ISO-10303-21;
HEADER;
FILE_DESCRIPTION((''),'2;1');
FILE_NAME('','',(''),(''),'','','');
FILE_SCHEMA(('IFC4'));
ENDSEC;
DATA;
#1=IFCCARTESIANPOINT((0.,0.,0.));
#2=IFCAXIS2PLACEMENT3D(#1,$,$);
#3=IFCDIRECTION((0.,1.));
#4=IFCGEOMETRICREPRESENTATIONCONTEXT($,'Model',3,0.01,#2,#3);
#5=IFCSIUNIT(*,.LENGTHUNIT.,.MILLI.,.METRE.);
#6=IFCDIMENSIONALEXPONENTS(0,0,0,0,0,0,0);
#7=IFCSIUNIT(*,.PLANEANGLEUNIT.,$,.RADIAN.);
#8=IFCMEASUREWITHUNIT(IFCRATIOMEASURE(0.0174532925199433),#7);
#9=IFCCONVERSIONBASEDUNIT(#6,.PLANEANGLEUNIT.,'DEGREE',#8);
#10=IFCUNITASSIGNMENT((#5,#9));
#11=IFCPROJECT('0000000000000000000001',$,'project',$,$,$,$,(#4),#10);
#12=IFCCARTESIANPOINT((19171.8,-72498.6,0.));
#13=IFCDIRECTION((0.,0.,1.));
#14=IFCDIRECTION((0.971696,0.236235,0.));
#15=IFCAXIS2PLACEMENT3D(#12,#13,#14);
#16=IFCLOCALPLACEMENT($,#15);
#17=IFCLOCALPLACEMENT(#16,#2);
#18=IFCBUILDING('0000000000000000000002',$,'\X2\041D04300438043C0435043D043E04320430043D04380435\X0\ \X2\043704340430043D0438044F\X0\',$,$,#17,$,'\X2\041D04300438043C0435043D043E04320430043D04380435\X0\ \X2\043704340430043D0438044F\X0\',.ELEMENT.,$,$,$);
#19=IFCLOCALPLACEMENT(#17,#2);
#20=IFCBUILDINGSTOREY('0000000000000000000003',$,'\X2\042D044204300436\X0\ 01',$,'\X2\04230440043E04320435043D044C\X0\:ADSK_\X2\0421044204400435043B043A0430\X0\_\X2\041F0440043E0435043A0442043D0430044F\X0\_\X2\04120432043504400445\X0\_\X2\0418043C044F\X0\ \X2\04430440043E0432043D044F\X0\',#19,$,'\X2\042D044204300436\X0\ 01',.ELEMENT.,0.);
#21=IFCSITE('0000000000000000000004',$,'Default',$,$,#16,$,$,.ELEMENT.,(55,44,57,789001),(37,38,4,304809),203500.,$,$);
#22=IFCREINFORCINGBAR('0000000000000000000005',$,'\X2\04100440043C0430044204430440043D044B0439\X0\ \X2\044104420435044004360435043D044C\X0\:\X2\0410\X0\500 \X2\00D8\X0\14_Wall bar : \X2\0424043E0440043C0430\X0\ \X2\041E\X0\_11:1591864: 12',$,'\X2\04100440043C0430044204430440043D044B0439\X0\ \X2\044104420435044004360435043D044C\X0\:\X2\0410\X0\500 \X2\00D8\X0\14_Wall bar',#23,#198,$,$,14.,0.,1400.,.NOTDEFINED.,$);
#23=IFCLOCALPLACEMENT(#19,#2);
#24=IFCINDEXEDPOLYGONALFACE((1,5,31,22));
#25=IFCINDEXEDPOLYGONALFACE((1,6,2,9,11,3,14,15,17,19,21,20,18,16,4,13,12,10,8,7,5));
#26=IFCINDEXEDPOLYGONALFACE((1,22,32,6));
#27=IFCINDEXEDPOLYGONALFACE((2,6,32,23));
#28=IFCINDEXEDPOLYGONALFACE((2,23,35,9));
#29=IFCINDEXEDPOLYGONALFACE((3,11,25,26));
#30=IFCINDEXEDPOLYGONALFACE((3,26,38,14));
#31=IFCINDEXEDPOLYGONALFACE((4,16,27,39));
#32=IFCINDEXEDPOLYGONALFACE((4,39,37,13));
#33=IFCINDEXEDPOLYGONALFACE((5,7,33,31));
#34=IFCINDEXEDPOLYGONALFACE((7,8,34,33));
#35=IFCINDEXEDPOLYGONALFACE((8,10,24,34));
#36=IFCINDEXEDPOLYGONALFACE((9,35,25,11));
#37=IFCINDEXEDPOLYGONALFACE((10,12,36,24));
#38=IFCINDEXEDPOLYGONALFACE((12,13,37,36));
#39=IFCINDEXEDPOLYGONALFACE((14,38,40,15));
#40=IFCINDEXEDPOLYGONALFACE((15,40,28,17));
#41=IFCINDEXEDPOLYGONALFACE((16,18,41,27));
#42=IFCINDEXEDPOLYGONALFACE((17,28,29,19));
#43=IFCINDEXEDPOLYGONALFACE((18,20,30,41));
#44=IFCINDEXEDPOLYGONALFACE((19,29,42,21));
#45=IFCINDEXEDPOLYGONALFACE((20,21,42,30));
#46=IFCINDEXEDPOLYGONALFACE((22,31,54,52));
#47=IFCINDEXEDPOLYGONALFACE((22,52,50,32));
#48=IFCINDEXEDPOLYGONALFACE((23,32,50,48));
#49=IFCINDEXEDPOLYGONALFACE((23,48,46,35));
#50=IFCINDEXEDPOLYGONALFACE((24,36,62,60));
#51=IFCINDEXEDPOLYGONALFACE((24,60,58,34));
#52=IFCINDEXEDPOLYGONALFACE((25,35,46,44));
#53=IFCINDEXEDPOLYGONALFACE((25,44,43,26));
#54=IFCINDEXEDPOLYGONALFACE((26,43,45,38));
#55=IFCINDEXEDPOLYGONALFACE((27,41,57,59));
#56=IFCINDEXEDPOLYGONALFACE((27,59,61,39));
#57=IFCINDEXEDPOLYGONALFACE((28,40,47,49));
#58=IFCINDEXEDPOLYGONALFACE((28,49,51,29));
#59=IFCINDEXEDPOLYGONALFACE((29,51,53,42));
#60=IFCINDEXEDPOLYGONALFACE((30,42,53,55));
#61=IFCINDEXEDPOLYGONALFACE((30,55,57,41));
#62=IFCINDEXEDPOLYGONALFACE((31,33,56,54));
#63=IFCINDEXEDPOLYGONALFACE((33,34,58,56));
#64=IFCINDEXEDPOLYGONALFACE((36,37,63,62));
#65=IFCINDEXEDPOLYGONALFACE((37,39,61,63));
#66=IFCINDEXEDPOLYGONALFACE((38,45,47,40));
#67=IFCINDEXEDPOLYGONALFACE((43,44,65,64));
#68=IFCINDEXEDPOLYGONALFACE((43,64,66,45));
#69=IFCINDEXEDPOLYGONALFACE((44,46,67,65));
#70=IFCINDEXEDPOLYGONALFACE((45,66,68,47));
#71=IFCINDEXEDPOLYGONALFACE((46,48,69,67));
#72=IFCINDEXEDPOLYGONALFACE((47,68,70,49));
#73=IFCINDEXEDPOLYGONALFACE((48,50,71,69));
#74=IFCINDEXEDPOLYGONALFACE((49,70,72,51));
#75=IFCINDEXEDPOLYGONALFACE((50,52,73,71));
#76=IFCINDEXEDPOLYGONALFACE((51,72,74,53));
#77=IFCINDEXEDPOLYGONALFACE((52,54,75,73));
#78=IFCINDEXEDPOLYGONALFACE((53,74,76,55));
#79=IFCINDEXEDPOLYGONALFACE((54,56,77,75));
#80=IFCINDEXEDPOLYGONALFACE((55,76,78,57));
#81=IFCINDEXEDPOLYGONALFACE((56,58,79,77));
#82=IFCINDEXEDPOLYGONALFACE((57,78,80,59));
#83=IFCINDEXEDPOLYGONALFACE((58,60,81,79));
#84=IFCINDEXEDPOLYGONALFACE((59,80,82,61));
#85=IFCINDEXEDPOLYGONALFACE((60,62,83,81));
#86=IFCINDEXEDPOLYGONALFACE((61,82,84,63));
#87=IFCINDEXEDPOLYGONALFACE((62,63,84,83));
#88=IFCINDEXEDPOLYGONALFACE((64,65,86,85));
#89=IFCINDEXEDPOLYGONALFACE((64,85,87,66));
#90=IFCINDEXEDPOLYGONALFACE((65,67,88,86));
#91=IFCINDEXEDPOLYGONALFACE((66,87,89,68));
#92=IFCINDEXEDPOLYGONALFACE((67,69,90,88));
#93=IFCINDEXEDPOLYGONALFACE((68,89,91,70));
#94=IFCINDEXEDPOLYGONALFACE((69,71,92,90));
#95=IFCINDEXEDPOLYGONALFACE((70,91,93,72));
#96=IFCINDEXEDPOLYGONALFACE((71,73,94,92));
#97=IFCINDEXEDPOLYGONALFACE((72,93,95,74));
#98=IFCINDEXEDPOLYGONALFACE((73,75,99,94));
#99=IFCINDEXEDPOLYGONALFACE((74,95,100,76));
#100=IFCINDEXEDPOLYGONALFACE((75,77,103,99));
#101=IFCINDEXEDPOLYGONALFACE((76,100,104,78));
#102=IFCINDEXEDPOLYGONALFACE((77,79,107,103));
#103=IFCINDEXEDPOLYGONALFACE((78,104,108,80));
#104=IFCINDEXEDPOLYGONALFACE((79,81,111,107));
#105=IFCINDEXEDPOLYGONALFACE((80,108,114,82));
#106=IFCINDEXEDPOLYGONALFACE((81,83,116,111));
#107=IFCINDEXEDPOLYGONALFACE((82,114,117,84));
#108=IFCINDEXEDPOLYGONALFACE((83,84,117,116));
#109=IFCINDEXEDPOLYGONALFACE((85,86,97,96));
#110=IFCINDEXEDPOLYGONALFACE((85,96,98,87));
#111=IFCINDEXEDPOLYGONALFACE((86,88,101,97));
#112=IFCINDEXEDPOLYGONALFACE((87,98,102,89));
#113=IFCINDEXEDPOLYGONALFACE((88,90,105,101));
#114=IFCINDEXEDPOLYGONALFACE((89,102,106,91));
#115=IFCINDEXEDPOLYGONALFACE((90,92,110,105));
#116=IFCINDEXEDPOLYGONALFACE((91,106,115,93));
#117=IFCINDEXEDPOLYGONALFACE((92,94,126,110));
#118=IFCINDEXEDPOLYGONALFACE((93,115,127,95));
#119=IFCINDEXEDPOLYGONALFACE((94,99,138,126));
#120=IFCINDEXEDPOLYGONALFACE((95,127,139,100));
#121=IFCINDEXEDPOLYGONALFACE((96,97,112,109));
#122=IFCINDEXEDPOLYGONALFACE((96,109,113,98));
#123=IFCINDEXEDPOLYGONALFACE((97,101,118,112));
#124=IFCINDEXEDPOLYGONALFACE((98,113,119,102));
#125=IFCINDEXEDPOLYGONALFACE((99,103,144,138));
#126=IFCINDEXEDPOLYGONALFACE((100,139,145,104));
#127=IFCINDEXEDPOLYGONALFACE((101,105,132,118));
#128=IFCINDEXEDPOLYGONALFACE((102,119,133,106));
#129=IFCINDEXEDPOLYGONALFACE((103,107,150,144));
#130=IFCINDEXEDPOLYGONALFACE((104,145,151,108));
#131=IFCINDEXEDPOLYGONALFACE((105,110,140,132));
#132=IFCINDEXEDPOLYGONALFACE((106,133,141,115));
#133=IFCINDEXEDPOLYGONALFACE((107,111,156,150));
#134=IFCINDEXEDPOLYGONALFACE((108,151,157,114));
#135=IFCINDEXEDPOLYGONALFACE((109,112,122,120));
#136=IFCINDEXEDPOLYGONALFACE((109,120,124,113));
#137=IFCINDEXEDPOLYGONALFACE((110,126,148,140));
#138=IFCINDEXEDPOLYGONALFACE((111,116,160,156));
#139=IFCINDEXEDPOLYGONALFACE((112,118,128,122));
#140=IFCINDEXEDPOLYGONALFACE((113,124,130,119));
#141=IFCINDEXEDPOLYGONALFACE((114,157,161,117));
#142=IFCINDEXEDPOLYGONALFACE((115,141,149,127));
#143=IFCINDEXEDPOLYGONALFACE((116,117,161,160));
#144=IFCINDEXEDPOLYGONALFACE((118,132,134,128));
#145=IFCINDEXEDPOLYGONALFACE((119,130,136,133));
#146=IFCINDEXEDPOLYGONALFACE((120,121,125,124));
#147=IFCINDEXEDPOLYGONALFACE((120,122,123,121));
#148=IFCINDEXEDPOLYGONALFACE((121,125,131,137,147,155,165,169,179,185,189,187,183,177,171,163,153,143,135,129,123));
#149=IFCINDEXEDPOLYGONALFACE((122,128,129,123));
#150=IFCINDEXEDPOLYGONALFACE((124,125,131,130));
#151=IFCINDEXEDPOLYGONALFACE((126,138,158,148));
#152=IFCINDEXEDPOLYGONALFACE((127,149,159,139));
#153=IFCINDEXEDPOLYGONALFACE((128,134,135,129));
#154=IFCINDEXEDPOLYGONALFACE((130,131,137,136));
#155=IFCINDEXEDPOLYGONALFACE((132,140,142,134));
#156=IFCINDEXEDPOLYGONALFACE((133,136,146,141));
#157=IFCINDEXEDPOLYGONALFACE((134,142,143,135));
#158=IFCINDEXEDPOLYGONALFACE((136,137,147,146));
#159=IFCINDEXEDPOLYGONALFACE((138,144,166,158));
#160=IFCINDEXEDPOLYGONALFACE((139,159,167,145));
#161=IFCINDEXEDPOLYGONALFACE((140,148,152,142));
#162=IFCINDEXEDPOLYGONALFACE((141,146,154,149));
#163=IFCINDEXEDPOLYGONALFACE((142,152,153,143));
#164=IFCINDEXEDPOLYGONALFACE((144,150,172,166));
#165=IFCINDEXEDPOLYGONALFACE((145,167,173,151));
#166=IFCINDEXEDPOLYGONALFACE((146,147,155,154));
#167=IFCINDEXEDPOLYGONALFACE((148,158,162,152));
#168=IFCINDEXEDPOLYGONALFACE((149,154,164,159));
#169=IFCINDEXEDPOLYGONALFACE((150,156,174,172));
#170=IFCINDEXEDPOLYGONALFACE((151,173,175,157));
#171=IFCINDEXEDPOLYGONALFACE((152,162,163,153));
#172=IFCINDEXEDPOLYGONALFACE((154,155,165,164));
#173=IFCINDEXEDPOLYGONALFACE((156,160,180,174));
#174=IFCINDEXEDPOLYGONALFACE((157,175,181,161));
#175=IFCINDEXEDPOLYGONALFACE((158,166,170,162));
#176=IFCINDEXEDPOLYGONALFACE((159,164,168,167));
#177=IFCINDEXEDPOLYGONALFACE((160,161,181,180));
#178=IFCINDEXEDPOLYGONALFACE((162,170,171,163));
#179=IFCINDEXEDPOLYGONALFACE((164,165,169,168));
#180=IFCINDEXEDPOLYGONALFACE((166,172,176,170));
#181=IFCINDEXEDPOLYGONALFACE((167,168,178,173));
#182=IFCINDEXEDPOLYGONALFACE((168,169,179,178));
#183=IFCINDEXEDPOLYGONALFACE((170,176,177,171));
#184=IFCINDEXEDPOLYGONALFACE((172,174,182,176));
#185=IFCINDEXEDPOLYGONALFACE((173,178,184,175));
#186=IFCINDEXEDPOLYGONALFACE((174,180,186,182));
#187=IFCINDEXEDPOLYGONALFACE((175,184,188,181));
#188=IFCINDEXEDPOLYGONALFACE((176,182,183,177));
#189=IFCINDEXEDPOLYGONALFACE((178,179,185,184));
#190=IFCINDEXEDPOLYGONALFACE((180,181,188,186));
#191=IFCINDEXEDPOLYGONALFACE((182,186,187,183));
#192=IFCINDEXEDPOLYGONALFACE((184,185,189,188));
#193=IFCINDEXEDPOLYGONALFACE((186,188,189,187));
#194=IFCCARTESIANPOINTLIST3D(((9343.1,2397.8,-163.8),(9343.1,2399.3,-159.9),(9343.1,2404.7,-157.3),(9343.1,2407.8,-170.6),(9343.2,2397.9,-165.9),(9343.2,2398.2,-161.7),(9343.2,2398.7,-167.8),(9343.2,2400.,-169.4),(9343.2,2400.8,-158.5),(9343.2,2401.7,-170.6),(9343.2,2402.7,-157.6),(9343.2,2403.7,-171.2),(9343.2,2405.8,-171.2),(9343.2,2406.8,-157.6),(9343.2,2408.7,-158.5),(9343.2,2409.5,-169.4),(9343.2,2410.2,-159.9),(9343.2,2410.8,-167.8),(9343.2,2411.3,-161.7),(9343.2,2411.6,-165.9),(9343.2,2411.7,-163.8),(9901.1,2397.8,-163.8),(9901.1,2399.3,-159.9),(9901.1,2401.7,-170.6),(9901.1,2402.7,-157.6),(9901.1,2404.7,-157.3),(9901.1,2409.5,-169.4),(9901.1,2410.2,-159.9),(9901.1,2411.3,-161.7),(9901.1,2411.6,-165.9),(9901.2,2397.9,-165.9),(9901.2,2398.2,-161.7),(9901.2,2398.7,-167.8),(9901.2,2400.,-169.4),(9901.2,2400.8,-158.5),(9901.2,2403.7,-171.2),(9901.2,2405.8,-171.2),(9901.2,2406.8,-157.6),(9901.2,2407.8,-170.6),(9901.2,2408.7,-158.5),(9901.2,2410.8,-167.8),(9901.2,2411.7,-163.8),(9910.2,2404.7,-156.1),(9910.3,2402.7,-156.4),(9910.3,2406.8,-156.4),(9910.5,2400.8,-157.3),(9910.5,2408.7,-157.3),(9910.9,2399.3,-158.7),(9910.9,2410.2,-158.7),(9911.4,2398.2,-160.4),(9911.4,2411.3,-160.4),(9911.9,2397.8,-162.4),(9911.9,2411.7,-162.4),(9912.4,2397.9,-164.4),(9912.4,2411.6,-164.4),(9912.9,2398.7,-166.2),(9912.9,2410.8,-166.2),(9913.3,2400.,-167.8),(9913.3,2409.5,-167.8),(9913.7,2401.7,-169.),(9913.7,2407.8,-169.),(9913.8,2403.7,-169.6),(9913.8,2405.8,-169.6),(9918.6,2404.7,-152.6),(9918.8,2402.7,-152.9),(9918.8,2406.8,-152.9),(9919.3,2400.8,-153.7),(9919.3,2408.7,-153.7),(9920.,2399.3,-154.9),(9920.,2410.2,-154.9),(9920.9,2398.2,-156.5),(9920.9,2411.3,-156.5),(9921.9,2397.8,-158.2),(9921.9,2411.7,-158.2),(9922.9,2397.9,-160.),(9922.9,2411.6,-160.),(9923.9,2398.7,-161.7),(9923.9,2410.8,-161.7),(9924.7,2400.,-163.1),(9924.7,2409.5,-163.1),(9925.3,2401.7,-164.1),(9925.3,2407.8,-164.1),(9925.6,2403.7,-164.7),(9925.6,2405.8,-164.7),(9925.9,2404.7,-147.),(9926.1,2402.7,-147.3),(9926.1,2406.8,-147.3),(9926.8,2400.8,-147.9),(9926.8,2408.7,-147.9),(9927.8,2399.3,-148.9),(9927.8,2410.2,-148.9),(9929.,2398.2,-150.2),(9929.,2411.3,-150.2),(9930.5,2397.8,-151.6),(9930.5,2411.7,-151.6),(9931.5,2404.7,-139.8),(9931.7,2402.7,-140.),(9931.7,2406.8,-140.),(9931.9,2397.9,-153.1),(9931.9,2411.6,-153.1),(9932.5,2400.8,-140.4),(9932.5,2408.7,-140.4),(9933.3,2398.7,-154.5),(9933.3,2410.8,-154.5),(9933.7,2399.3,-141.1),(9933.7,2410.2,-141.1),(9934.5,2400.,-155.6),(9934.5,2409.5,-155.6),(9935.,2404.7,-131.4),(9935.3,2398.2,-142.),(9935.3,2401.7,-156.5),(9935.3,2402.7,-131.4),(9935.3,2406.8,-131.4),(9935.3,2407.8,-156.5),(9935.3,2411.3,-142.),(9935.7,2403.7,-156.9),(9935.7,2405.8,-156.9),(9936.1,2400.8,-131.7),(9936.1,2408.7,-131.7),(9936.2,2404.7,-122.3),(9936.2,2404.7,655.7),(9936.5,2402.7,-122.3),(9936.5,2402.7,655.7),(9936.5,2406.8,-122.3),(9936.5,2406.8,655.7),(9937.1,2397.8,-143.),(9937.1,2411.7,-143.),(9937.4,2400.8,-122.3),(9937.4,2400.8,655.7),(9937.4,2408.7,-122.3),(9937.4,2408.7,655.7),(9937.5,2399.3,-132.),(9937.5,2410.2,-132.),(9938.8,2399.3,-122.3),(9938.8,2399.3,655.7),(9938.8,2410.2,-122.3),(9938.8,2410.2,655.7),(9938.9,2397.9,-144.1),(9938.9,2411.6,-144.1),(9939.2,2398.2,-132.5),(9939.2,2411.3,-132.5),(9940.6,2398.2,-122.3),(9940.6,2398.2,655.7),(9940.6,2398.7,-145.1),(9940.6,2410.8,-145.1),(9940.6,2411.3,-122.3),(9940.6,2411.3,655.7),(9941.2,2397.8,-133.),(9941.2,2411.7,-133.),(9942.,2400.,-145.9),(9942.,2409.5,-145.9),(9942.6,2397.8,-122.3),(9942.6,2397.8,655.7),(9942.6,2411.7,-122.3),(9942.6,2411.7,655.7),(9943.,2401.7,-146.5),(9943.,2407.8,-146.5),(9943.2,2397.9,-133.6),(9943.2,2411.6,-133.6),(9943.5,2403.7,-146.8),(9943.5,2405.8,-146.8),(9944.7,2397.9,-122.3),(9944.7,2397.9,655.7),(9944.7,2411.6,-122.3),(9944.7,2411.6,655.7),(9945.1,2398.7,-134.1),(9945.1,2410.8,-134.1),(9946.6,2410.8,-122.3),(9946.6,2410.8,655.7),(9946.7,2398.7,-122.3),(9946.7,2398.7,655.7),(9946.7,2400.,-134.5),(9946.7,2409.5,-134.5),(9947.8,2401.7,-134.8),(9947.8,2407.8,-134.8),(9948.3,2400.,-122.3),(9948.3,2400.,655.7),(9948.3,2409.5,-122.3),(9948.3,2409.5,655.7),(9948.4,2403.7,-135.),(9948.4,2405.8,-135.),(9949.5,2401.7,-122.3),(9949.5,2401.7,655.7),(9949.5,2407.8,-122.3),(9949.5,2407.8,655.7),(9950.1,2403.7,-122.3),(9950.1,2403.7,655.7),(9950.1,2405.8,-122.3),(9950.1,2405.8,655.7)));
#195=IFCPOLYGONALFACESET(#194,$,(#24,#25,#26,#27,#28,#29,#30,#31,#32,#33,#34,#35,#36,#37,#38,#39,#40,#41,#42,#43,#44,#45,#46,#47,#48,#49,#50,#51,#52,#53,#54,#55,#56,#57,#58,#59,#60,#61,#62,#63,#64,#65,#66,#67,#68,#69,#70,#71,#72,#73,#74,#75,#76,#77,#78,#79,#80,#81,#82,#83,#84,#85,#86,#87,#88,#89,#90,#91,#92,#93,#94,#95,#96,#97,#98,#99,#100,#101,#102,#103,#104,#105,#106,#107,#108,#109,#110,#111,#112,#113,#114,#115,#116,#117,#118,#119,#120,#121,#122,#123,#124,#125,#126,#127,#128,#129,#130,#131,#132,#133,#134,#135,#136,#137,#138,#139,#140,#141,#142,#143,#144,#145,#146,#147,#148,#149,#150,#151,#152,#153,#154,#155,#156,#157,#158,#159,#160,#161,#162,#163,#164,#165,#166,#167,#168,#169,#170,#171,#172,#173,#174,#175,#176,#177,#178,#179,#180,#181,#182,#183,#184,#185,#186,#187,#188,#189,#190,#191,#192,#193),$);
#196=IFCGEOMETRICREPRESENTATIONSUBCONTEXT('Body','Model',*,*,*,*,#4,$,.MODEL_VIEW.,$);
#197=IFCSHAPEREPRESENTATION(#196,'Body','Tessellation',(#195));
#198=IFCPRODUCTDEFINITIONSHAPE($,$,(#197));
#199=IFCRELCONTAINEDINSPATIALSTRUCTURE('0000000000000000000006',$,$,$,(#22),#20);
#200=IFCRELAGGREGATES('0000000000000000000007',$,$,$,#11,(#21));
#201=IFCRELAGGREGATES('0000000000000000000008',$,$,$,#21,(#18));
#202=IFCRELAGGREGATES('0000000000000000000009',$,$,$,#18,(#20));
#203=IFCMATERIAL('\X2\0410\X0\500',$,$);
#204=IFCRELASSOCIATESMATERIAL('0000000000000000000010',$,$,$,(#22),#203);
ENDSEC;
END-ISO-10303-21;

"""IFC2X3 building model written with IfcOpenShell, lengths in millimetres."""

from ifc_helpers import new_model, entity, si_unit, converted_unit, direction, frame, origin, place, context, subcontext, project, spatial, material, element, save


model = new_model("IFC2X3")

# Units and contexts
model_context = context("Model", 3, precision=0.01, world=origin(), true_north=direction((0.0, 1.0)))
body_context = subcontext(model_context, "Body", "Model", "MODEL_VIEW")
ifc_project = project(units=[si_unit("LENGTHUNIT", "METRE", prefix="MILLI"), converted_unit("PLANEANGLEUNIT", "DEGREE", entity("IfcRatioMeasure", 0.0174532925199433), si_unit("PLANEANGLEUNIT", "RADIAN"), dimensions=[0, 0, 0, 0, 0, 0, 0])], contexts=[model_context])

# Site, building, storey
site_placement = place(None, frame((19171.8, -72498.6, 0.0), z_axis=(0.0, 0.0, 1.0), x_axis=(0.971696, 0.236235, 0.0)))
site = spatial("IfcSite", under=ifc_project, at=site_placement, Name="Default", CompositionType="ELEMENT", RefLatitude=(55, 44, 57, 789001), RefLongitude=(37, 38, 4, 304809), RefElevation=203500.0)
building_placement = place(site_placement, origin())
building = spatial("IfcBuilding", under=site, at=building_placement, Name="Наименование здания", LongName="Наименование здания", CompositionType="ELEMENT")
storey_placement = place(building_placement, origin())
storey = spatial("IfcBuildingStorey", under=building, at=storey_placement, Name="Этаж 01", ObjectType="Уровень:ADSK_Стрелка_Проектная_Вверх_Имя уровня", LongName="Этаж 01", CompositionType="ELEMENT", Elevation=0.0)

# Reinforcing bar
ifc_material = material(Name="А500")
placement = place(storey_placement, origin())
element("IfcReinforcingBar", 1, at=placement, inside=storey, material=ifc_material, Name="Арматурный стержень:А500 Ø14_Wall bar : Форма О_11:1591864: 12", ObjectType="Арматурный стержень:А500 Ø14_Wall bar", BarLength=1400.0, BarRole="NOTDEFINED", CrossSectionArea=0.0, NominalDiameter=14.0, context=body_context, shape_type="AdvancedSweptSolid", body=[
    entity("IfcSweptDiskSolid", entity("IfcCompositeCurve", [entity("IfcCompositeCurveSegment", "CONTINUOUS", True, entity("IfcPolyline", [entity("IfcCartesianPoint", [9943.1, 2404.7, 655.7]), entity("IfcCartesianPoint", [9943.1, 2404.7, -122.3])])), entity("IfcCompositeCurveSegment", "CONTINUOUS", True, entity("IfcTrimmedCurve", entity("IfcCircle", entity("IfcAxis2Placement3D", entity("IfcCartesianPoint", [9901.1, 2404.7, -122.3]), entity("IfcDirection", [0.0, 1.0, 0.0]), entity("IfcDirection", [0.0, 0.0, -1.0])), 42.0), [entity("IfcParameterValue", 270.0)], [entity("IfcParameterValue", 360.0)], True, "PARAMETER")), entity("IfcCompositeCurveSegment", "CONTINUOUS", True, entity("IfcPolyline", [entity("IfcCartesianPoint", [9901.1, 2404.7, -164.3]), entity("IfcCartesianPoint", [9343.1, 2404.7, -164.3])]))], False), 7.0, None, 0.0, 92.0),
])

save(model, "model.ifc")
